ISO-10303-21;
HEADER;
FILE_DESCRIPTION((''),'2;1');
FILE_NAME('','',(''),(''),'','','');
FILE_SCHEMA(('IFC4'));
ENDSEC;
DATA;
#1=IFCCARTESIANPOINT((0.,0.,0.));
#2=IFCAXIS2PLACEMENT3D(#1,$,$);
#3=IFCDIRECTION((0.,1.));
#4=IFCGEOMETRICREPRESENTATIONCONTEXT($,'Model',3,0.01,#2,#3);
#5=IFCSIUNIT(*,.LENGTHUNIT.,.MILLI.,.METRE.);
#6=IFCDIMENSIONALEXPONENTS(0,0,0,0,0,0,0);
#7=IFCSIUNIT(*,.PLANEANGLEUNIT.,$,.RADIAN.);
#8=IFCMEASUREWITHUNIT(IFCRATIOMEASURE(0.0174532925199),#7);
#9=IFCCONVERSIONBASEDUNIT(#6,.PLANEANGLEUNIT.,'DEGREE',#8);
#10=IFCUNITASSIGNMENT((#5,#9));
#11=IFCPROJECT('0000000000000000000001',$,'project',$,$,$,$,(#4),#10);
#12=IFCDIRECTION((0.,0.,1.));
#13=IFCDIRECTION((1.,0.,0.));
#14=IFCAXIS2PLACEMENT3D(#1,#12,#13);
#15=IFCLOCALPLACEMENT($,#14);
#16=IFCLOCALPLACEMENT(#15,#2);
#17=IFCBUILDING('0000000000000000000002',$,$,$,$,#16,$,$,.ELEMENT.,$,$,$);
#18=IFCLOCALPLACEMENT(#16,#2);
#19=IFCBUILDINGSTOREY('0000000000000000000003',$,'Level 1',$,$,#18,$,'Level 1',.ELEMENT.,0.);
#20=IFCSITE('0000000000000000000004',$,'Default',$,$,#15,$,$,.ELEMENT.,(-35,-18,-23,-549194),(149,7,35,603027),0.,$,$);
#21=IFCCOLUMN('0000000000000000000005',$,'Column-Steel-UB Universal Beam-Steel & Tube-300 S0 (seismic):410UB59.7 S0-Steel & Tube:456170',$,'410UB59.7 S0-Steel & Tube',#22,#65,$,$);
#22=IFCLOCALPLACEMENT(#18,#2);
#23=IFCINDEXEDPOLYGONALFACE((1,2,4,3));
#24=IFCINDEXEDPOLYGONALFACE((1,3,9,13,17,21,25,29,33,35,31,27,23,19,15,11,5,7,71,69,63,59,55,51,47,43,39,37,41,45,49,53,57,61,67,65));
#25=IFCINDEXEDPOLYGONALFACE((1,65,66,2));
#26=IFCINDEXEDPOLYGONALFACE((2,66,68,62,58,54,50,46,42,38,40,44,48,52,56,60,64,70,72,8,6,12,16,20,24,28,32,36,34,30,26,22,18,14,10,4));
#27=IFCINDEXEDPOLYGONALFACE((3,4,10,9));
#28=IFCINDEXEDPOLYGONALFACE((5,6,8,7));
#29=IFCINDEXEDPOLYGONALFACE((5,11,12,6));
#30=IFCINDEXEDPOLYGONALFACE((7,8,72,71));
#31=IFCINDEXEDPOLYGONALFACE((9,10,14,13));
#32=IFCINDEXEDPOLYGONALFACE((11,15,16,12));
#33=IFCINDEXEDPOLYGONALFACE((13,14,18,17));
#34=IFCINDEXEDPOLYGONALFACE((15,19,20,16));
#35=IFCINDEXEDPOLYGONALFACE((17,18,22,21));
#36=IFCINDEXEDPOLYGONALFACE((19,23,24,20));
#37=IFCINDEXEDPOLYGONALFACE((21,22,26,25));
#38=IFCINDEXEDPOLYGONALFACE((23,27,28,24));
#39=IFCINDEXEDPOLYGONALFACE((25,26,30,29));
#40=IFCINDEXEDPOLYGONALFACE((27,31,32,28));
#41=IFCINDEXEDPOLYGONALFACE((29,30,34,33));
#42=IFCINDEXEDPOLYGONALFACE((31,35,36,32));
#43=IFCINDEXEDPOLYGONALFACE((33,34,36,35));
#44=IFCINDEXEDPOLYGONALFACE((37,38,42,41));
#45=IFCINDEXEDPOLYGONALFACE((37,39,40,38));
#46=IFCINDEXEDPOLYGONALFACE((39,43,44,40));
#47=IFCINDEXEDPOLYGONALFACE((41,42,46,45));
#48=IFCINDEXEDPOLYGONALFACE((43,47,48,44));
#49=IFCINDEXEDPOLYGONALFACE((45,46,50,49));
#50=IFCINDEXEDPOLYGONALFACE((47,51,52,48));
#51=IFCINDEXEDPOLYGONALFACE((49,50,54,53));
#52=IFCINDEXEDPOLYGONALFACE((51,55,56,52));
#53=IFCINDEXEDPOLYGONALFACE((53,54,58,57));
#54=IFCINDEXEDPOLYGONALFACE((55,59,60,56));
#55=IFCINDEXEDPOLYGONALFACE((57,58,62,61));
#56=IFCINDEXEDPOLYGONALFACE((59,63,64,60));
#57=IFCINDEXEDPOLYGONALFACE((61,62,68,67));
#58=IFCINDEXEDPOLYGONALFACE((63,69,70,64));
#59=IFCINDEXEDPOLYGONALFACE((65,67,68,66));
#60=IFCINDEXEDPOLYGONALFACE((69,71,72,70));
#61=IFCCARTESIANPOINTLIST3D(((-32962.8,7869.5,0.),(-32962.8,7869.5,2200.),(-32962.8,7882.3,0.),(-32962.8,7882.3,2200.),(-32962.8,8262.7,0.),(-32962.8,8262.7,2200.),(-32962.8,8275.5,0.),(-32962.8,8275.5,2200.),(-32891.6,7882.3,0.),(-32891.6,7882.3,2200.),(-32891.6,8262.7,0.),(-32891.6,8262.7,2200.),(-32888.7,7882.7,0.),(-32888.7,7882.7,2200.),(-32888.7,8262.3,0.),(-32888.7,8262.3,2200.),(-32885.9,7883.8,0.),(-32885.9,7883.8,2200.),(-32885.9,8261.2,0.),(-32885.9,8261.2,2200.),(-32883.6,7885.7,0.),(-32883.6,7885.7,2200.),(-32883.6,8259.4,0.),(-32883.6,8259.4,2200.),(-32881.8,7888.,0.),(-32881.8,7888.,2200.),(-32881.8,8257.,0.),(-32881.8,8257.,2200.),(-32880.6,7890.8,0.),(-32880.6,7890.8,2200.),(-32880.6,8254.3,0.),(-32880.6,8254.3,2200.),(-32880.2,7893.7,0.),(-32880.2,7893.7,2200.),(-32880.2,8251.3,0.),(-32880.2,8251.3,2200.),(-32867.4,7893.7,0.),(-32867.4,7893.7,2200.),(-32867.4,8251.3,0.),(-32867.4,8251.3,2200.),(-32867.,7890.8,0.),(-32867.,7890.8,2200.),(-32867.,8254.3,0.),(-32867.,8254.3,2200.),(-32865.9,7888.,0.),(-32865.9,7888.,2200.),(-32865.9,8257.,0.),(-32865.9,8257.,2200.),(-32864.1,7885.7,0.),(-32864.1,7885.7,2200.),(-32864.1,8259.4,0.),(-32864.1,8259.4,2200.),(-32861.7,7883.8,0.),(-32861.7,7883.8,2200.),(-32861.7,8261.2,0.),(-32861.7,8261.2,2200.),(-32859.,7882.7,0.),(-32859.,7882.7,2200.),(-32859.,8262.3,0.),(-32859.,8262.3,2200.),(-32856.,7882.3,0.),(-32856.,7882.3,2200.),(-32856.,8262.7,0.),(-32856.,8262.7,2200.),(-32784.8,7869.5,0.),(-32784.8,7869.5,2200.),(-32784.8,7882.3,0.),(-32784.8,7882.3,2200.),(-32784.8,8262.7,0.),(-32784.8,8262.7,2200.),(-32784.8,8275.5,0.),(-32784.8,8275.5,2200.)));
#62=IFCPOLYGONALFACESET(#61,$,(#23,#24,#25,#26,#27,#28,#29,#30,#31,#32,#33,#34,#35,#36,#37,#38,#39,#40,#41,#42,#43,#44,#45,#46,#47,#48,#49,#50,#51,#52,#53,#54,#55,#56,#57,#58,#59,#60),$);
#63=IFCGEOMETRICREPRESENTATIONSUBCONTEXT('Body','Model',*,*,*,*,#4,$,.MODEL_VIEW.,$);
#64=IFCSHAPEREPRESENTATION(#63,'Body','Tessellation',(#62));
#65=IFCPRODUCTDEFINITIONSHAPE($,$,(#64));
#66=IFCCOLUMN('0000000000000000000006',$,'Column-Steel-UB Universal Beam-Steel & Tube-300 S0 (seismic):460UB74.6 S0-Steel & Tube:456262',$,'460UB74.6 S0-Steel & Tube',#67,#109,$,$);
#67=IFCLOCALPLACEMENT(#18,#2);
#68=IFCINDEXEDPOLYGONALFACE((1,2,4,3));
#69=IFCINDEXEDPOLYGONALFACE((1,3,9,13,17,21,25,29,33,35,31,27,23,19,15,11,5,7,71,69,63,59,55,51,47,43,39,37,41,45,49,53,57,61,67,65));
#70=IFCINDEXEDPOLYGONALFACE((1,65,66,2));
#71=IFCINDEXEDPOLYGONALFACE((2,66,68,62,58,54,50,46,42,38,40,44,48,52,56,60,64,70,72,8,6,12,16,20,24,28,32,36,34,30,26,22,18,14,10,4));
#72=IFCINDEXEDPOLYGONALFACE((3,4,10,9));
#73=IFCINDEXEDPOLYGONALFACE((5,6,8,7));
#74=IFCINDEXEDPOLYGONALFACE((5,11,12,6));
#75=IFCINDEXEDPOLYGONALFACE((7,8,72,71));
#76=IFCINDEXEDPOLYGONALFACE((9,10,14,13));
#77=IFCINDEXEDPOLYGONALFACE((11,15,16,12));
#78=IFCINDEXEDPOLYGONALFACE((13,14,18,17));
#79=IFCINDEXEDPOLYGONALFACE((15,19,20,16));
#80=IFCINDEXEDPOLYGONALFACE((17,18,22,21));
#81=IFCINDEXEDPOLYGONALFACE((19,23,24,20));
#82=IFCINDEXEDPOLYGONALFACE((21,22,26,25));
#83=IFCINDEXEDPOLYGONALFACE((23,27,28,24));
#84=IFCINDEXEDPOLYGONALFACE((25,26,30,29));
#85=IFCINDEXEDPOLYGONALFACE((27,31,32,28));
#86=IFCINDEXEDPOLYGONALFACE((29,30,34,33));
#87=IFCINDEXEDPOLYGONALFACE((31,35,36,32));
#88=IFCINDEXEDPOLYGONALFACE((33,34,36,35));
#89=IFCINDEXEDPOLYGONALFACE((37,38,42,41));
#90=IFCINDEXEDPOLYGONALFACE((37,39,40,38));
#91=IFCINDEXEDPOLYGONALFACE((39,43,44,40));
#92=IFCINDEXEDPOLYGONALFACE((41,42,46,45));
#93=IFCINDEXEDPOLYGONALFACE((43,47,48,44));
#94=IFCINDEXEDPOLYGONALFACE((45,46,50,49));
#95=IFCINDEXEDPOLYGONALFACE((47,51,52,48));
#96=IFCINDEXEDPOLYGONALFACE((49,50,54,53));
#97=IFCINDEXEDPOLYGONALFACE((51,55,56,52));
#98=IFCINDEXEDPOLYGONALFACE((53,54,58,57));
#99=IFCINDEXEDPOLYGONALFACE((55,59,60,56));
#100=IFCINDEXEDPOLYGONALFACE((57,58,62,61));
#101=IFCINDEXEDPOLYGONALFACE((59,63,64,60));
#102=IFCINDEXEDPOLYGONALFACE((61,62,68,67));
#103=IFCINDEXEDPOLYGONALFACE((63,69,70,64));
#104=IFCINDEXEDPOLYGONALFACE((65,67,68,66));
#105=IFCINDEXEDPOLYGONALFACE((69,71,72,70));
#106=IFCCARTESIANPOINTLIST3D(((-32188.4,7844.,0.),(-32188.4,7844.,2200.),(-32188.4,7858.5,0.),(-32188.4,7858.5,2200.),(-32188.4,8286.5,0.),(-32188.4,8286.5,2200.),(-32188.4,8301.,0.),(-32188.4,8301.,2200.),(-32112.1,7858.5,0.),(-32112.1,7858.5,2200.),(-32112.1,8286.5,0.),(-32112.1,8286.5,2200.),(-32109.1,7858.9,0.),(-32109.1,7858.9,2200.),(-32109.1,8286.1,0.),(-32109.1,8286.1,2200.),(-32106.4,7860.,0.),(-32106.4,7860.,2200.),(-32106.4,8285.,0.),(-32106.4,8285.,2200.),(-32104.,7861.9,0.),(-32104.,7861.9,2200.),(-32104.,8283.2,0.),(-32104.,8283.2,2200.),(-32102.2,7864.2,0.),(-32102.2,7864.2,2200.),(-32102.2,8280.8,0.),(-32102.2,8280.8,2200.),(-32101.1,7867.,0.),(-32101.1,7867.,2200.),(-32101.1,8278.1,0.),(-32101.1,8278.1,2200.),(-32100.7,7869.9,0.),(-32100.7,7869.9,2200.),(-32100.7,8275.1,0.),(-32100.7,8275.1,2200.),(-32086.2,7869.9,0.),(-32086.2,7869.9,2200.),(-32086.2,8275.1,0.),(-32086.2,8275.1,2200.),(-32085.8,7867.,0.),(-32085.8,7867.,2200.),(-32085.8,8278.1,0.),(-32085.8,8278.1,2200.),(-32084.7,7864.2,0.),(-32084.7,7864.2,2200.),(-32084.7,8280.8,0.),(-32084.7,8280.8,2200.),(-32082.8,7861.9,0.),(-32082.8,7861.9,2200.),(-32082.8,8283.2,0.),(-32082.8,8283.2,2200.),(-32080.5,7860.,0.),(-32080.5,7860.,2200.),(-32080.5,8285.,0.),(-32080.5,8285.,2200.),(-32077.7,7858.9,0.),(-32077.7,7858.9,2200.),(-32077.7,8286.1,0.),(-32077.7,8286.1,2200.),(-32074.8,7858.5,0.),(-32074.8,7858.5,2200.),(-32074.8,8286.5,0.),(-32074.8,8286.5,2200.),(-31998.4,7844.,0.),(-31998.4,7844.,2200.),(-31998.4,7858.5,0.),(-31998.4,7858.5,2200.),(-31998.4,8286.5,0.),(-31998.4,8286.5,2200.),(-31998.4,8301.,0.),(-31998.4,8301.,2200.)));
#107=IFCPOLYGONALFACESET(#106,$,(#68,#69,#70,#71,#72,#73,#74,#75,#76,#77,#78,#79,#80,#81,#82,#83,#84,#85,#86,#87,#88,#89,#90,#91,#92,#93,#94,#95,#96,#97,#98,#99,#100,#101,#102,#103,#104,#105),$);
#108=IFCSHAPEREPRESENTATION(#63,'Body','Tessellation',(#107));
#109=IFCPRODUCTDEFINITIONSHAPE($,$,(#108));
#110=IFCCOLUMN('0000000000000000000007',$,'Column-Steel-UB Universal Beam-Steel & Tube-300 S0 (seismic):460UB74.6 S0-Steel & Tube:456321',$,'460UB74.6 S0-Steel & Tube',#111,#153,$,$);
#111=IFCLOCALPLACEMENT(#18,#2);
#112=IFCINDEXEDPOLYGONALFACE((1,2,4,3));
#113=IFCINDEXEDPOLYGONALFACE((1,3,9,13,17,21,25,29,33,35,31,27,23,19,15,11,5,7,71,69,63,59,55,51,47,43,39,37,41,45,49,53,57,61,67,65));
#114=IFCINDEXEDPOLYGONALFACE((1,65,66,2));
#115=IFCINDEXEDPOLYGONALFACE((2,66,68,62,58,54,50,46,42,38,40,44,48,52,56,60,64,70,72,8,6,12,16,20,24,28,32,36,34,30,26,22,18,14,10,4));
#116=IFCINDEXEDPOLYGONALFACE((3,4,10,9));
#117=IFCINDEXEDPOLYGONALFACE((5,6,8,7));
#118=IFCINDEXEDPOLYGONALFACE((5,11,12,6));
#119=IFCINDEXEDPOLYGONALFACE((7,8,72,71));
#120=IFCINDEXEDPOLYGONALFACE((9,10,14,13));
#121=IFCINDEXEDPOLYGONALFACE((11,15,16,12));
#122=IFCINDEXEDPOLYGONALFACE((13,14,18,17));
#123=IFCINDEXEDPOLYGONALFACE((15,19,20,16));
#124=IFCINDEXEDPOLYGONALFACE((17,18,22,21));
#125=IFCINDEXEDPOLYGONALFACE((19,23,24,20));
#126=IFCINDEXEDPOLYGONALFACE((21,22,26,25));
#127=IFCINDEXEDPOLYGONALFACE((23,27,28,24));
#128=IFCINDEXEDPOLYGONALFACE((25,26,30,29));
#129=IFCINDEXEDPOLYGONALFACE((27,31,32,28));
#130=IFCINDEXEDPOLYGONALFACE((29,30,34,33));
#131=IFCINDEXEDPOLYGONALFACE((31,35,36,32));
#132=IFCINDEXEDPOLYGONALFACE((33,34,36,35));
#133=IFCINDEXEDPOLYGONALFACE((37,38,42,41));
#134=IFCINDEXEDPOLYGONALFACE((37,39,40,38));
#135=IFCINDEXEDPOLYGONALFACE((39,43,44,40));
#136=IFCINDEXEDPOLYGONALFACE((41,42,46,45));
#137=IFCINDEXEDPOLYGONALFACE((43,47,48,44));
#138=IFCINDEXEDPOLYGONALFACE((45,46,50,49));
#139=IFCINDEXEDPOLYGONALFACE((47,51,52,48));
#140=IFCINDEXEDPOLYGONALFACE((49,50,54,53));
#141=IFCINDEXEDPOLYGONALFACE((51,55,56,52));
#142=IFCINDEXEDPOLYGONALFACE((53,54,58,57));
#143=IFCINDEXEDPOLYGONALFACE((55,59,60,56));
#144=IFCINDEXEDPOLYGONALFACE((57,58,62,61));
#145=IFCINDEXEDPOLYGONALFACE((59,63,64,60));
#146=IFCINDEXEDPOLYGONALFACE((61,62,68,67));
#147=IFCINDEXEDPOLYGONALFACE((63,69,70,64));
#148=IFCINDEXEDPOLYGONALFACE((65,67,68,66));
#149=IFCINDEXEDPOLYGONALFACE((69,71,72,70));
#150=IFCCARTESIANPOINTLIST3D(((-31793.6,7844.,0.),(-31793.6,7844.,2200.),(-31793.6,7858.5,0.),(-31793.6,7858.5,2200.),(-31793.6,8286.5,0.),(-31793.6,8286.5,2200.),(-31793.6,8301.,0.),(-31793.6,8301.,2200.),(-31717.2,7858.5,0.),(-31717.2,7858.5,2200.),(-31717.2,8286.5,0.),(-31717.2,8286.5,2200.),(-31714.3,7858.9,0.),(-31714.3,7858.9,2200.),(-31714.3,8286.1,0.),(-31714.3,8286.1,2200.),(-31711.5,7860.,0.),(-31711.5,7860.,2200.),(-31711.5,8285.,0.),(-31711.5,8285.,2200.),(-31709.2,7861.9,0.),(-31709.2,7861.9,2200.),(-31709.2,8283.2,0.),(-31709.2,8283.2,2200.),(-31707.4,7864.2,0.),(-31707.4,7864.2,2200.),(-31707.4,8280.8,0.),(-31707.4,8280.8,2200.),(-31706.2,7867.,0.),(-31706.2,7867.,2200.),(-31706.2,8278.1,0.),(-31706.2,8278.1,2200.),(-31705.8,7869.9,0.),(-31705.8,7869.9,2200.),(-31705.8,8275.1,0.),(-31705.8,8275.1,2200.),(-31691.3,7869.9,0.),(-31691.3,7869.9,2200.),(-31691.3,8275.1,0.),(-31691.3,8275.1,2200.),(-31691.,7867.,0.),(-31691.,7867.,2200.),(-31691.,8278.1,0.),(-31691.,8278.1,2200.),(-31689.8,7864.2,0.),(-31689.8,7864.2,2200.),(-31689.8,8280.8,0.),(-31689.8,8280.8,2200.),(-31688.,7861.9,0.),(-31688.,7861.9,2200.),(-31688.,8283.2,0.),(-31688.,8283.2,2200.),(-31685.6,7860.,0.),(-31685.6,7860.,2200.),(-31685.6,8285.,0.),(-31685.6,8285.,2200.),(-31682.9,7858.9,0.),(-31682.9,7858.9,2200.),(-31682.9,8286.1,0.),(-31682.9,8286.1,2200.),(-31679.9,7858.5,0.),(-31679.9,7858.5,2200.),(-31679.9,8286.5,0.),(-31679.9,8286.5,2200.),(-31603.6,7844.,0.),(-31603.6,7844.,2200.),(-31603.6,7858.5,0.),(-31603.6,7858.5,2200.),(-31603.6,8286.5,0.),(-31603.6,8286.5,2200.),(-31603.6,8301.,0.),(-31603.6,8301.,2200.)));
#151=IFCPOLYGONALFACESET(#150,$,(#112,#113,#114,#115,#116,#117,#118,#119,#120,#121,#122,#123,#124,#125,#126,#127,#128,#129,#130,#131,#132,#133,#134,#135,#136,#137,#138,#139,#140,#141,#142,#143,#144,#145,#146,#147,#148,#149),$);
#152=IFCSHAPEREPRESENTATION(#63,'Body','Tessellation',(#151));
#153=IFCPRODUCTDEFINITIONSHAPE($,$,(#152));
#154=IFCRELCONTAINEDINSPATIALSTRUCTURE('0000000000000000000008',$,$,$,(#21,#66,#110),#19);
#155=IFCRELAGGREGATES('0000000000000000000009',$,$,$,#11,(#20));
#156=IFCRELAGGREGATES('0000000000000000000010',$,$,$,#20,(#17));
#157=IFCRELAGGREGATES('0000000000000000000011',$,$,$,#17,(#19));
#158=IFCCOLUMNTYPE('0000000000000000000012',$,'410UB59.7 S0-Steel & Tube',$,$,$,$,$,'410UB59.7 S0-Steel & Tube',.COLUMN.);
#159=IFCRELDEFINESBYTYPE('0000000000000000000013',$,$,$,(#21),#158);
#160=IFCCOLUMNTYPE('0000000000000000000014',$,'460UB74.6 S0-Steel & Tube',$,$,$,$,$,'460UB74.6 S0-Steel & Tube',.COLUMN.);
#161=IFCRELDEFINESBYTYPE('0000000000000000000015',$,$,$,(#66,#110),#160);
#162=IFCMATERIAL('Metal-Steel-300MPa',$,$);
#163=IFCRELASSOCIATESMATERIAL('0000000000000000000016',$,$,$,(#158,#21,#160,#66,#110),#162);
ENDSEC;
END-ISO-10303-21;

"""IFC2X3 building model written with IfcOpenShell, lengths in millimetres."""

from ifc_helpers import new_model, entity, si_unit, converted_unit, direction, frame, frame_2d, origin, origin_with_axes, place, context, subcontext, project, spatial, polyline, circle_curve, parameter, trimmed, segment, composite_curve, outline, extrude, source, transform, mapped, material, type_object, type_shapes, element, save


model = new_model("IFC2X3")

# Units and contexts
model_context = context("Model", 3, precision=0.01, world=origin(), true_north=direction((0.0, 1.0)))
body_context = subcontext(model_context, "Body", "Model", "MODEL_VIEW")
ifc_project = project(units=[si_unit("LENGTHUNIT", "METRE", prefix="MILLI"), converted_unit("PLANEANGLEUNIT", "DEGREE", entity("IfcRatioMeasure", 0.0174532925199), si_unit("PLANEANGLEUNIT", "RADIAN"), dimensions=[0, 0, 0, 0, 0, 0, 0])], contexts=[model_context])

# Site, building, storey
site_placement = place(None, origin_with_axes())
site = spatial("IfcSite", under=ifc_project, at=site_placement, Name="Default", CompositionType="ELEMENT", RefLatitude=(-35, -18, -23, -549194), RefLongitude=(149, 7, 35, 603027), RefElevation=0.0)
building_placement = place(site_placement, origin())
building = spatial("IfcBuilding", under=site, at=building_placement, CompositionType="ELEMENT")
storey_placement = place(building_placement, origin())
storey = spatial("IfcBuildingStorey", under=building, at=storey_placement, Name="Level 1", LongName="Level 1", CompositionType="ELEMENT", Elevation=0.0)

# Columns
ifc_material = material(Name="Metal-Steel-300MPa")
column_type_1 = type_object("IfcColumnType", Name="410UB59.7 S0-Steel & Tube", ElementType="410UB59.7 S0-Steel & Tube", PredefinedType="COLUMN", material=ifc_material)
shared_shape_1 = source(origin(), body_context, "Body", "SweptSolid", [
    extrude(outline(composite_curve([segment(polyline([(190.2, -89.0), (203.0, -89.0)]), True, "CONTINUOUS"), segment(polyline([(203.0, -89.0), (203.0, 89.0)]), True, "CONTINUOUS"), segment(polyline([(203.0, 89.0), (190.2, 89.0)]), True, "CONTINUOUS"), segment(polyline([(190.2, 89.0), (190.2, 17.8)]), True, "CONTINUOUS"), segment(trimmed(circle_curve(frame_2d((178.8, 17.8), x_axis=(1.0, 0.0)), 11.4), [parameter(270.0)], [parameter(0.0)], True, "PARAMETER"), False, "CONTINUOUS"), segment(polyline([(178.8, 6.4), (-178.8, 6.4)]), True, "CONTINUOUS"), segment(trimmed(circle_curve(frame_2d((-178.8, 17.8), x_axis=(0.0, -1.0)), 11.4), [parameter(270.0)], [parameter(0.0)], True, "PARAMETER"), False, "CONTINUOUS"), segment(polyline([(-190.2, 17.8), (-190.2, 89.0)]), True, "CONTINUOUS"), segment(polyline([(-190.2, 89.0), (-203.0, 89.0)]), True, "CONTINUOUS"), segment(polyline([(-203.0, 89.0), (-203.0, -89.0)]), True, "CONTINUOUS"), segment(polyline([(-203.0, -89.0), (-190.2, -89.0)]), True, "CONTINUOUS"), segment(polyline([(-190.2, -89.0), (-190.2, -17.8)]), True, "CONTINUOUS"), segment(trimmed(circle_curve(frame_2d((-178.8, -17.8), x_axis=(-1.0, 0.0)), 11.4), [parameter(270.0)], [parameter(0.0)], True, "PARAMETER"), False, "CONTINUOUS"), segment(polyline([(-178.8, -6.4), (178.8, -6.4)]), True, "CONTINUOUS"), segment(trimmed(circle_curve(frame_2d((178.8, -17.8), x_axis=(0.0, 1.0)), 11.4), [parameter(270.0)], [parameter(0.0)], True, "PARAMETER"), False, "CONTINUOUS"), segment(polyline([(190.2, -17.8), (190.2, -89.0)]), True, "CONTINUOUS")], self_intersect=False)), frame((0.0, 0.0, 0.0), z_axis=(0.0, 0.0, 1.0), x_axis=(0.0, -1.0, 0.0)), (0.0, 0.0, 1.0), 2200.0),
])
type_shapes(column_type_1, [shared_shape_1])
column_1_placement = place(storey_placement, frame((-32873.8, 8072.5, 0.0)))
element("IfcColumn", 1, at=column_1_placement, inside=storey, type_object=column_type_1, material=ifc_material, Name="Column-Steel-UB Universal Beam-Steel & Tube-300 S0 (seismic):410UB59.7 S0-Steel & Tube:456170", ObjectType="410UB59.7 S0-Steel & Tube", context=body_context, shape_type="MappedRepresentation", body=[
    mapped(shared_shape_1, transform((0.0, 0.0, 0.0), scale=1.0)),
])
column_type_2 = type_object("IfcColumnType", Name="460UB74.6 S0-Steel & Tube", ElementType="460UB74.6 S0-Steel & Tube", PredefinedType="COLUMN", material=ifc_material)
shared_shape_2 = source(origin(), body_context, "Body", "SweptSolid", [
    extrude(outline(composite_curve([segment(polyline([(214.0, -95.0), (228.5, -95.0)]), True, "CONTINUOUS"), segment(polyline([(228.5, -95.0), (228.5, 95.0)]), True, "CONTINUOUS"), segment(polyline([(228.5, 95.0), (214.0, 95.0)]), True, "CONTINUOUS"), segment(polyline([(214.0, 95.0), (214.0, 18.6)]), True, "CONTINUOUS"), segment(trimmed(circle_curve(frame_2d((202.6, 18.6), x_axis=(1.0, 0.0)), 11.4), [parameter(270.0)], [parameter(0.0)], True, "PARAMETER"), False, "CONTINUOUS"), segment(polyline([(202.6, 7.2), (-202.6, 7.2)]), True, "CONTINUOUS"), segment(trimmed(circle_curve(frame_2d((-202.6, 18.6), x_axis=(0.0, -1.0)), 11.4), [parameter(270.0)], [parameter(0.0)], True, "PARAMETER"), False, "CONTINUOUS"), segment(polyline([(-214.0, 18.6), (-214.0, 95.0)]), True, "CONTINUOUS"), segment(polyline([(-214.0, 95.0), (-228.5, 95.0)]), True, "CONTINUOUS"), segment(polyline([(-228.5, 95.0), (-228.5, -95.0)]), True, "CONTINUOUS"), segment(polyline([(-228.5, -95.0), (-214.0, -95.0)]), True, "CONTINUOUS"), segment(polyline([(-214.0, -95.0), (-214.0, -18.6)]), True, "CONTINUOUS"), segment(trimmed(circle_curve(frame_2d((-202.6, -18.6), x_axis=(-1.0, 0.0)), 11.4), [parameter(270.0)], [parameter(0.0)], True, "PARAMETER"), False, "CONTINUOUS"), segment(polyline([(-202.6, -7.2), (202.6, -7.2)]), True, "CONTINUOUS"), segment(trimmed(circle_curve(frame_2d((202.6, -18.6), x_axis=(0.0, 1.0)), 11.4), [parameter(270.0)], [parameter(0.0)], True, "PARAMETER"), False, "CONTINUOUS"), segment(polyline([(214.0, -18.6), (214.0, -95.0)]), True, "CONTINUOUS")], self_intersect=False)), frame((0.0, 0.0, 0.0), z_axis=(0.0, 0.0, 1.0), x_axis=(0.0, -1.0, 0.0)), (0.0, 0.0, 1.0), 2200.0),
])
type_shapes(column_type_2, [shared_shape_2])
for number, where, name in (
    (2, (-32093.4, 8072.5, 0.0), "Column-Steel-UB Universal Beam-Steel & Tube-300 S0 (seismic):460UB74.6 S0-Steel & Tube:456262"),
    (3, (-31698.6, 8072.5, 0.0), "Column-Steel-UB Universal Beam-Steel & Tube-300 S0 (seismic):460UB74.6 S0-Steel & Tube:456321"),
):
    element("IfcColumn", number, at=place(storey_placement, frame(where)), inside=storey, type_object=column_type_2, material=ifc_material, Name=name, ObjectType="460UB74.6 S0-Steel & Tube", context=body_context, shape_type="MappedRepresentation", body=[
        mapped(shared_shape_2, transform((0.0, 0.0, 0.0), scale=1.0)),
    ])

save(model, "model.ifc")
